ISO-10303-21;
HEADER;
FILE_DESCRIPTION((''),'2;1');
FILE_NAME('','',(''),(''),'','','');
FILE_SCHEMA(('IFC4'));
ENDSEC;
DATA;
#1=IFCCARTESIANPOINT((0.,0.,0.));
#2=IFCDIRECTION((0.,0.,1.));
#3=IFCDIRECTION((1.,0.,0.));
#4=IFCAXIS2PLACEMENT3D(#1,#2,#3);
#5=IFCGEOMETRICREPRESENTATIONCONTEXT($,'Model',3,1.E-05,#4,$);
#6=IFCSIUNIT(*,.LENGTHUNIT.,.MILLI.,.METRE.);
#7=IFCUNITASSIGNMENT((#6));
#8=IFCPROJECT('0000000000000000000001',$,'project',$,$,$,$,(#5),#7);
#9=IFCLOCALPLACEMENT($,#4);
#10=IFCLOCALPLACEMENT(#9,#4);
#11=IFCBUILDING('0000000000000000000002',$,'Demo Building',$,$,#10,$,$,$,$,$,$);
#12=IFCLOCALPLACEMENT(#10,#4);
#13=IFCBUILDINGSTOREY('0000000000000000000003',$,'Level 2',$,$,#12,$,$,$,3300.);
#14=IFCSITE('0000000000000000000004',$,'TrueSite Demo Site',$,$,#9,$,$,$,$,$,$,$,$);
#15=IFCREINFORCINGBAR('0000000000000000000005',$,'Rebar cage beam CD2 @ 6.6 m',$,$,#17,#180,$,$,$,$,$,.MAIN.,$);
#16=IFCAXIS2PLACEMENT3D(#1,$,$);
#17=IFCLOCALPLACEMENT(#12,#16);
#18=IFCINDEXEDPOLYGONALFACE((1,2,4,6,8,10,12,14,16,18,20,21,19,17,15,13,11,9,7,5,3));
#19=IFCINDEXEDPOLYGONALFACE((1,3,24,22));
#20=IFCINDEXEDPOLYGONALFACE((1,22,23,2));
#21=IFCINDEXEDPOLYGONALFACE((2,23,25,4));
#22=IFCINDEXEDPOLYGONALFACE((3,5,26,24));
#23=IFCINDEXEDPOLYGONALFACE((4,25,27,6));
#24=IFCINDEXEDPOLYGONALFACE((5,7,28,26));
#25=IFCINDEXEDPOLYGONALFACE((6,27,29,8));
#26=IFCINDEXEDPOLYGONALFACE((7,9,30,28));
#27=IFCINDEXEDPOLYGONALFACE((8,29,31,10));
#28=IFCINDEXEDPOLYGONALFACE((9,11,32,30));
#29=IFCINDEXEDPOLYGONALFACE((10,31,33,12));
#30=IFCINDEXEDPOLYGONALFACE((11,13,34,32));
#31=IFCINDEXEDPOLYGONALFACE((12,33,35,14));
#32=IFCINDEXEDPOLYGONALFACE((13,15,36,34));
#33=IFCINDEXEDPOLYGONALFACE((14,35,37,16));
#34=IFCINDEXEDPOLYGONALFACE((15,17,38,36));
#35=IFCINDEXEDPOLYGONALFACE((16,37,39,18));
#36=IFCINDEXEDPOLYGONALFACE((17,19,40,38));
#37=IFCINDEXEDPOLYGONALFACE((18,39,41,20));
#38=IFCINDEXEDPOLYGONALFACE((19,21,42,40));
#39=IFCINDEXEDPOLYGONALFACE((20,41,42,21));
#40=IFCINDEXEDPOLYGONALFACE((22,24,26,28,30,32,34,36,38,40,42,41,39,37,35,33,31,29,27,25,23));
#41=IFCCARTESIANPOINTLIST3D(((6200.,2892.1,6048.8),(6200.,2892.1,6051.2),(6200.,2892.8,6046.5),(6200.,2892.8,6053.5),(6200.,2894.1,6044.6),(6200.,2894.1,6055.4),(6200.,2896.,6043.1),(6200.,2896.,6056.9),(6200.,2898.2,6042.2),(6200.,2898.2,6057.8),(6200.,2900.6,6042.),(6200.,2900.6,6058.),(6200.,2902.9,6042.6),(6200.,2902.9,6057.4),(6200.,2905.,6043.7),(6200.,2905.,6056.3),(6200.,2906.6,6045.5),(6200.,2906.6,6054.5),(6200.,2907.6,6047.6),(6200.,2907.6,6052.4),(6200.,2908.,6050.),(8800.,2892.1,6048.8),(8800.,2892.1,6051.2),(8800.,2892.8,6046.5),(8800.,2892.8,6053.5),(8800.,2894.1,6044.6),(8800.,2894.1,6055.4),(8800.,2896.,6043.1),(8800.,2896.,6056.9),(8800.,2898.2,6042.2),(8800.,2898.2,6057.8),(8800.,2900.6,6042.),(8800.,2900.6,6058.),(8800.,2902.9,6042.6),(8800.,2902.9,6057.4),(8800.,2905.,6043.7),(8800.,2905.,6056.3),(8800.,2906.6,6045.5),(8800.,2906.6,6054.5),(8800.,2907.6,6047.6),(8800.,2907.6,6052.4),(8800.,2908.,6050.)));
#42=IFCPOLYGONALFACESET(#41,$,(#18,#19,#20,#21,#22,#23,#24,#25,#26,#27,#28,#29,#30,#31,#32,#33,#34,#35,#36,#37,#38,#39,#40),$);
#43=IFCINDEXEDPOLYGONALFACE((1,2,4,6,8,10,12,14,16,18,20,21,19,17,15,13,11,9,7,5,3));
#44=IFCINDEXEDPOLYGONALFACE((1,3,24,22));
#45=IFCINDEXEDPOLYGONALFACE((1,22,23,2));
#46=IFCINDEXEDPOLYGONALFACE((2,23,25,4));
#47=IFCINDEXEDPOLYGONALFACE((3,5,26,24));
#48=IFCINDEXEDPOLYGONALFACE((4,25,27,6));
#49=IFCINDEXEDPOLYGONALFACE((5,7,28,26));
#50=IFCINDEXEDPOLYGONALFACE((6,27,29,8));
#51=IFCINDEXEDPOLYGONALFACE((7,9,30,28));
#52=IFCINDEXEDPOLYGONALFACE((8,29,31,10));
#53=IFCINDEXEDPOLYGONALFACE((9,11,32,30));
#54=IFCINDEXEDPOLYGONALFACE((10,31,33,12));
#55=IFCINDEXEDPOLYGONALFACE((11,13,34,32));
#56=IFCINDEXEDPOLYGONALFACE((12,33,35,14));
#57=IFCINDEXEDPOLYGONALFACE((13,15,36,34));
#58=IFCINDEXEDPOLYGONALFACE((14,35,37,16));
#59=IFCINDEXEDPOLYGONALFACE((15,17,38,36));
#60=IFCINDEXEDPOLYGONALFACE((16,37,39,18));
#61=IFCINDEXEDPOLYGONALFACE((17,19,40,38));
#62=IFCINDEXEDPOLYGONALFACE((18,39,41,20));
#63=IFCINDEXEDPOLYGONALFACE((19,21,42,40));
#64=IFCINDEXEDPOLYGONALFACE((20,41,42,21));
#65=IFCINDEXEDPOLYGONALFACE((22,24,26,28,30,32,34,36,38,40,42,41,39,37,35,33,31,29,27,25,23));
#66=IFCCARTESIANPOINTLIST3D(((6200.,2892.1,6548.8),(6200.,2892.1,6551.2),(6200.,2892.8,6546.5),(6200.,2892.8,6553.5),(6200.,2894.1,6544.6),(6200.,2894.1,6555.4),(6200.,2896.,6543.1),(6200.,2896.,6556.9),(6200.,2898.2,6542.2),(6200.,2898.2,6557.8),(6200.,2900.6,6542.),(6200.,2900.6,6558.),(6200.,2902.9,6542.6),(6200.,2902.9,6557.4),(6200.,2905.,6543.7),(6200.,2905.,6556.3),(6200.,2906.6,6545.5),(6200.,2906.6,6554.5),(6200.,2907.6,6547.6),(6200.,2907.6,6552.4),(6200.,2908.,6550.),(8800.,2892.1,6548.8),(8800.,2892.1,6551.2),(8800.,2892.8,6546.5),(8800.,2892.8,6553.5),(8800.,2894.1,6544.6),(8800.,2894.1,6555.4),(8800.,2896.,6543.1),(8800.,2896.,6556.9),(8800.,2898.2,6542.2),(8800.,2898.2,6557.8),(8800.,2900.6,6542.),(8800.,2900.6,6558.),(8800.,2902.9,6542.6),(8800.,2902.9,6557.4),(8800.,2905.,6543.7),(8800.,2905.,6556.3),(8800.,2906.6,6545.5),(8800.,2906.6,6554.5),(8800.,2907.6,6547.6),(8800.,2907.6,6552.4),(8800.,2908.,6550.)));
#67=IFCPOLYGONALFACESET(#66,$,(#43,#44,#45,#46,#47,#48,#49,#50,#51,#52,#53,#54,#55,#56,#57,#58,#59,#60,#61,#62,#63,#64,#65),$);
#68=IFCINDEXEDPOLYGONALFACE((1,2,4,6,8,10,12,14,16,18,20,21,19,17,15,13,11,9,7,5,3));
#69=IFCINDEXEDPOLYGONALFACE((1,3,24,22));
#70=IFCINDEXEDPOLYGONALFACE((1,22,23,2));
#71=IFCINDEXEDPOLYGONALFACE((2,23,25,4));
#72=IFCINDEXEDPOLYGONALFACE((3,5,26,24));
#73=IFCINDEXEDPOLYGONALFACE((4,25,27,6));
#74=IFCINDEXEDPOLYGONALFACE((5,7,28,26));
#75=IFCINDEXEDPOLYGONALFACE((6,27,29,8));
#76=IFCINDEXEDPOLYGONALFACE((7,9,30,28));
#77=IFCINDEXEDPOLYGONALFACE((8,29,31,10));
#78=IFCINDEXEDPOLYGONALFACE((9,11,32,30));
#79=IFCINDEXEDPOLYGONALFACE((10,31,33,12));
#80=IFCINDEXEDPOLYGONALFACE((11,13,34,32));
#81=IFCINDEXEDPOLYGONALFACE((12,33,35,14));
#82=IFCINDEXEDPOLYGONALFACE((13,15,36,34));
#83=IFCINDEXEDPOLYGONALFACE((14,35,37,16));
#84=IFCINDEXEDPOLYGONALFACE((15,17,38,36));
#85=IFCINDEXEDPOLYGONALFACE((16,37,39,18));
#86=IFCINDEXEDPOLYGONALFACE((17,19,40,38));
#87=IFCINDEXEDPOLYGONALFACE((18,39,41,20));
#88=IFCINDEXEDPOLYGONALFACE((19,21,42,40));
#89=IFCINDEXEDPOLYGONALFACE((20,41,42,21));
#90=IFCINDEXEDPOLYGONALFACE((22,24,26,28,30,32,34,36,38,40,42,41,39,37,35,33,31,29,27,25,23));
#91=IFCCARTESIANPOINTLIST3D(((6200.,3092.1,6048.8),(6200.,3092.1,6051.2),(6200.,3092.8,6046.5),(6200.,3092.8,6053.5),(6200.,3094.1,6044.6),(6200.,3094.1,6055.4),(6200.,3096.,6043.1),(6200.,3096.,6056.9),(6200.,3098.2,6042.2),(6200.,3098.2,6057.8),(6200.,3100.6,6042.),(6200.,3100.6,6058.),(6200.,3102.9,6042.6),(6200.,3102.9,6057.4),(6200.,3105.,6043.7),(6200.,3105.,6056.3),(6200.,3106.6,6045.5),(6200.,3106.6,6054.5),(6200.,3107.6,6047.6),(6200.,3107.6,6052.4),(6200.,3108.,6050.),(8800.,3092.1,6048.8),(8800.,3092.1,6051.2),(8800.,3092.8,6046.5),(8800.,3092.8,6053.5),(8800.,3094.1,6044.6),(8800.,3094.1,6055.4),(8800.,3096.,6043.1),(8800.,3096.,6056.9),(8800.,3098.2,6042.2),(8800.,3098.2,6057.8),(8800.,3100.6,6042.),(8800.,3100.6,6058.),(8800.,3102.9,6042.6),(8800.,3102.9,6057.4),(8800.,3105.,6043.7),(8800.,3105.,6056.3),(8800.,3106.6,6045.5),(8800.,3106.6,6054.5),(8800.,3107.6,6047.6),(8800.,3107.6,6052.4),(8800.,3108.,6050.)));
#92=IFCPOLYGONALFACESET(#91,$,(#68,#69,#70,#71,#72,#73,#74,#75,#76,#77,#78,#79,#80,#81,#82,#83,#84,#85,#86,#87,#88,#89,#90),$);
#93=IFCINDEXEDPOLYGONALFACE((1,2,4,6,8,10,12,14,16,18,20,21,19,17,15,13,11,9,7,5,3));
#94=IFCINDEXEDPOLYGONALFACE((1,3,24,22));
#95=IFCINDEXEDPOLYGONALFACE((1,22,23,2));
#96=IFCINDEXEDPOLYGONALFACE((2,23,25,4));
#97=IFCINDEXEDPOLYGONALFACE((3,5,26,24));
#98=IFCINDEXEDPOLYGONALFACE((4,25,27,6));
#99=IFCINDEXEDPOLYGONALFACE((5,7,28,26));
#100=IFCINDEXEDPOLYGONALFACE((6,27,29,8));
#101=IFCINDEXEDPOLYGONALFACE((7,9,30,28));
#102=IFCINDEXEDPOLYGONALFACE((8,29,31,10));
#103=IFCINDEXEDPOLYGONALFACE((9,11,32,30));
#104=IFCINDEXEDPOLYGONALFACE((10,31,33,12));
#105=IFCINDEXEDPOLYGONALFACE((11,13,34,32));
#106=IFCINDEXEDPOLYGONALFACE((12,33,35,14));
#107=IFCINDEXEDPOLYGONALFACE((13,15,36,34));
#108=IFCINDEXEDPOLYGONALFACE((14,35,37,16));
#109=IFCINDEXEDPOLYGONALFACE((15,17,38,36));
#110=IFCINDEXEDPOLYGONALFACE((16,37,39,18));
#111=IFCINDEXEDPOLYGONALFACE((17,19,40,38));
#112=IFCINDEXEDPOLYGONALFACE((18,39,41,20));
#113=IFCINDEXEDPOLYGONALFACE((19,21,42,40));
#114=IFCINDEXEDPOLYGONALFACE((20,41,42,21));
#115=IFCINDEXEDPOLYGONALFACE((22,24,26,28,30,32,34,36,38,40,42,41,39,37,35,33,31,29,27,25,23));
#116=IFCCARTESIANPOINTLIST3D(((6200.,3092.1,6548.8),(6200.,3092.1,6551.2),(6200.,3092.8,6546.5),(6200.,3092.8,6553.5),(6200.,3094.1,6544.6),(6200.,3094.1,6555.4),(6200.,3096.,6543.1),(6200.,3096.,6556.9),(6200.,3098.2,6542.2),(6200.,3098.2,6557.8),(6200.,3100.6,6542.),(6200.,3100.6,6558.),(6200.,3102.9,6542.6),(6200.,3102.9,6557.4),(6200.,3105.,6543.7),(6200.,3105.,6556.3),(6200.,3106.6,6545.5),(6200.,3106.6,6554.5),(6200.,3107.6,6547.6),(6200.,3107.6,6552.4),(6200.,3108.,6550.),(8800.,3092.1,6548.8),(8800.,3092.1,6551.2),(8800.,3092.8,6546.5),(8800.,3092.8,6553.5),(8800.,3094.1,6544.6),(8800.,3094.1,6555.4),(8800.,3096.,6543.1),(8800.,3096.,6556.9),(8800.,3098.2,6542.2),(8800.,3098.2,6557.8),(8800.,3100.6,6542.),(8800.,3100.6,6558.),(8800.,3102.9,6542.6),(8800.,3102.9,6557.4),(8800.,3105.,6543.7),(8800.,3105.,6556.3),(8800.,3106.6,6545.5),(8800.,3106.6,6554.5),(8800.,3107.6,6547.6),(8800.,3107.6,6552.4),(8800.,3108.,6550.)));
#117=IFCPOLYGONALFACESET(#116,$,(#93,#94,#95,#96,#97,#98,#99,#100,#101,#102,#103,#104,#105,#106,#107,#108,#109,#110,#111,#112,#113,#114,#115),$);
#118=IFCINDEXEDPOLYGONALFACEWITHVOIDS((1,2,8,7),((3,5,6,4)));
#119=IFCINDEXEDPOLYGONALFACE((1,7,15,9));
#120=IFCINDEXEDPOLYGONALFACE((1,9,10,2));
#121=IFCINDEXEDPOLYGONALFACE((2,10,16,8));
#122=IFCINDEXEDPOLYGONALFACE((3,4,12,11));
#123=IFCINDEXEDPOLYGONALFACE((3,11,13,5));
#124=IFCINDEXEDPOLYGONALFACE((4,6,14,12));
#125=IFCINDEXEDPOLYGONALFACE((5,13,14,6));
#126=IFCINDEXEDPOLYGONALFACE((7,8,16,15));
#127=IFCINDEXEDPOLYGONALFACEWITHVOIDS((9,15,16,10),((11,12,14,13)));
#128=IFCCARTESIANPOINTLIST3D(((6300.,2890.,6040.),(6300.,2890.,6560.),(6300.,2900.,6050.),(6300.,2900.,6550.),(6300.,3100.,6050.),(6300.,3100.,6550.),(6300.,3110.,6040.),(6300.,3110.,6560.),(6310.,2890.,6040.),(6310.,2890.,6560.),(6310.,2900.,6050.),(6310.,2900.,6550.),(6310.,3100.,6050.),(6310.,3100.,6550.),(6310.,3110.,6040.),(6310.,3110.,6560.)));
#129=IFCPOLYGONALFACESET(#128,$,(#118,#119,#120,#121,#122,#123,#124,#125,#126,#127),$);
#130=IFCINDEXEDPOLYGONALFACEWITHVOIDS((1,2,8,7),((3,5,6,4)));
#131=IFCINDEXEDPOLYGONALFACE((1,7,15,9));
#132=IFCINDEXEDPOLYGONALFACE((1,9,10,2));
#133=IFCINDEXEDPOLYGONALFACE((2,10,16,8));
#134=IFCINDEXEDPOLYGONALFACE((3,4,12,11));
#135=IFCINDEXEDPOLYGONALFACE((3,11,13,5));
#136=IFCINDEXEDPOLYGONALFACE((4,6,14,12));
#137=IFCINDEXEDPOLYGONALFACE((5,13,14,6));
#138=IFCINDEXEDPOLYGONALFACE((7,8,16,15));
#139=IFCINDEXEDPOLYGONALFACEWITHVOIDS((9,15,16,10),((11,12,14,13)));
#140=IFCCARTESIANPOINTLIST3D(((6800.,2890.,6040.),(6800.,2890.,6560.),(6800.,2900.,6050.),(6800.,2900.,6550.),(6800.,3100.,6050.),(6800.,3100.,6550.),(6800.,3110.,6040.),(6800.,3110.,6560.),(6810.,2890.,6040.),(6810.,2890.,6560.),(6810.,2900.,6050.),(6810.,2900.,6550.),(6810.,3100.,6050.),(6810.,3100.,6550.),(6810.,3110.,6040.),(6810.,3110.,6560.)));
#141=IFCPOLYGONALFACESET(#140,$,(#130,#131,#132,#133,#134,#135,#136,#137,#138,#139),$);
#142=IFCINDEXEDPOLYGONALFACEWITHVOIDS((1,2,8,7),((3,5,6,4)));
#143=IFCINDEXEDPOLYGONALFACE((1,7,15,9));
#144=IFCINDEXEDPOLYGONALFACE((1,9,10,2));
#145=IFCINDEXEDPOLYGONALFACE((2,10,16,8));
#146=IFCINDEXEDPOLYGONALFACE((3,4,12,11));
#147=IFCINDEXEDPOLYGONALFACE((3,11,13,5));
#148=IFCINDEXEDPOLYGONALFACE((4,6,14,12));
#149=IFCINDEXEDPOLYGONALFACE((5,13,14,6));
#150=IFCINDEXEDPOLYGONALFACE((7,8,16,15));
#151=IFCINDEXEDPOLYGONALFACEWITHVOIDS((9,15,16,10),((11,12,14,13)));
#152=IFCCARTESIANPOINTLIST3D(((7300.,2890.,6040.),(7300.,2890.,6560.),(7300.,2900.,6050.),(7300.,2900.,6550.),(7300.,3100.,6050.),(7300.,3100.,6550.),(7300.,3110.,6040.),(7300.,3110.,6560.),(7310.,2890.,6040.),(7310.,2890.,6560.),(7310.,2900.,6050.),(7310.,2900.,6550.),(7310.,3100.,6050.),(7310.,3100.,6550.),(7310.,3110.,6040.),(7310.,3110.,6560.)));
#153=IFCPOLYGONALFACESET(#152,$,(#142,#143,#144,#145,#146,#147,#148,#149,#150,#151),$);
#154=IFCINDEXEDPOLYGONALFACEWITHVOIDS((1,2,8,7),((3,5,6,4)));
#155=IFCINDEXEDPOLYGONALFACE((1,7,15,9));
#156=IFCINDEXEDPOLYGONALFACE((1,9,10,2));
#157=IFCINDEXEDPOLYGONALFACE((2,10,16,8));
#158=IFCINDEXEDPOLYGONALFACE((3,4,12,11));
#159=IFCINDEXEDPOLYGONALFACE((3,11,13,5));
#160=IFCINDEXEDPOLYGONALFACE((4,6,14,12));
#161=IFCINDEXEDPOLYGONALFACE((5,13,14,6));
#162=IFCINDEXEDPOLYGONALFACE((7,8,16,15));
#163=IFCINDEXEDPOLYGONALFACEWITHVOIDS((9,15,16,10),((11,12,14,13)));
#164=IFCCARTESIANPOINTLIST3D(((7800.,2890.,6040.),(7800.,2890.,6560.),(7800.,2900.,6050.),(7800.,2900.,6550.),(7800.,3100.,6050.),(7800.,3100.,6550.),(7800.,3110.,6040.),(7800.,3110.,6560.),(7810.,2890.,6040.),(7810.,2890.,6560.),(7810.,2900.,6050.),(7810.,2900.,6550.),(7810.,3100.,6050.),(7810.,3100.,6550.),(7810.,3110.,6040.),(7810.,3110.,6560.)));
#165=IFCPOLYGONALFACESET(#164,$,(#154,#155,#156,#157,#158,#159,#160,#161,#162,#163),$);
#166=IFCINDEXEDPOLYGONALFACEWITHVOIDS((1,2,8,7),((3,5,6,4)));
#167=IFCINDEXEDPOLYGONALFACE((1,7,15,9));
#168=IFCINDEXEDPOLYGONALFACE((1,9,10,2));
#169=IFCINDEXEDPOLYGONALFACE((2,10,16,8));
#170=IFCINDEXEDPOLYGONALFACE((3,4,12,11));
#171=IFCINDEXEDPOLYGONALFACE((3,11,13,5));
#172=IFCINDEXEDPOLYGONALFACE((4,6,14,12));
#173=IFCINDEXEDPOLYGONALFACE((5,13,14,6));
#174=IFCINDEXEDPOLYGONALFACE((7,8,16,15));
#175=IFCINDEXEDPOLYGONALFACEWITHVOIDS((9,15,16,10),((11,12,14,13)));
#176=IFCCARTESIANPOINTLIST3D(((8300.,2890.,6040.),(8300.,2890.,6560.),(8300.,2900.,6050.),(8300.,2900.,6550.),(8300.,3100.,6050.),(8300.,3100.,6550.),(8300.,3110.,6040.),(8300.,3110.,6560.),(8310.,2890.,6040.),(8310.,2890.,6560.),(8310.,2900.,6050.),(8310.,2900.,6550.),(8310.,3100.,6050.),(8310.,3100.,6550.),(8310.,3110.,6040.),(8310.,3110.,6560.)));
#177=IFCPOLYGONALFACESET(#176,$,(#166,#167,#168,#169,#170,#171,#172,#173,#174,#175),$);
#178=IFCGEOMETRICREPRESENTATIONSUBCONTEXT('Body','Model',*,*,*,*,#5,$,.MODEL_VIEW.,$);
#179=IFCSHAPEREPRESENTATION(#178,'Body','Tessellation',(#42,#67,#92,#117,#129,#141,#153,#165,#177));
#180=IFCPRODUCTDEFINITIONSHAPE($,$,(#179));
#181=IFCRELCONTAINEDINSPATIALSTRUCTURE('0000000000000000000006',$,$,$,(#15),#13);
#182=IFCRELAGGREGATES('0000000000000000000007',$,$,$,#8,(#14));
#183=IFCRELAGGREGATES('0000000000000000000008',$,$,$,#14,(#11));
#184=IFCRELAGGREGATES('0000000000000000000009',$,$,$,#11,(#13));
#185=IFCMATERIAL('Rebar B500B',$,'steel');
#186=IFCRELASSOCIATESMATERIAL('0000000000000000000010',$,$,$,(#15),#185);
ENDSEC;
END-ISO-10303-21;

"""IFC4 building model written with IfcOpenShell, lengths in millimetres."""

from ifc_helpers import new_model, si_unit, frame, origin_with_axes, place, context, subcontext, project, spatial, hollow_rectangle, circle, extrude, material, element, save


model = new_model("IFC4")

# Units and contexts
model_context = context("Model", 3, precision=1e-05, world=origin_with_axes())
body_context = subcontext(model_context, "Body", "Model", "MODEL_VIEW")
ifc_project = project(units=[si_unit("LENGTHUNIT", "METRE", prefix="MILLI")], contexts=[model_context])

# Site, building, storey
site_placement = place(None, origin_with_axes())
site = spatial("IfcSite", under=ifc_project, at=site_placement, Name="TrueSite Demo Site")
building_placement = place(site_placement, origin_with_axes())
building = spatial("IfcBuilding", under=site, at=building_placement, Name="Demo Building")
storey_placement = place(building_placement, origin_with_axes())
storey = spatial("IfcBuildingStorey", under=building, at=storey_placement, Name="Level 2", Elevation=3300.0)

# Reinforcing bar
ifc_material_1 = material(Name="Rebar B500B", Category="steel")
for number, where, z_axis, x_axis, name in (
    (1, (6200.0, 3000.0, 6300.0), (1.0, 0.0, 0.0), (0.0, 1.0, 0.0), "Rebar cage beam CD2 @ 6.6 m"),
):
    element("IfcReinforcingBar", number, at=place(storey_placement, frame(where, z_axis=z_axis, x_axis=x_axis)), inside=storey, material=ifc_material_1, Name=name, PredefinedType="MAIN", context=body_context, shape_type="SweptSolid", body=[
        extrude(circle(Radius=8.0), frame((-100.0, -250.0, 0.0)), (0.0, 0.0, 1.0), 2600.0),
        extrude(circle(Radius=8.0), frame((-100.0, 250.0, 0.0)), (0.0, 0.0, 1.0), 2600.0),
        extrude(circle(Radius=8.0), frame((100.0, -250.0, 0.0)), (0.0, 0.0, 1.0), 2600.0),
        extrude(circle(Radius=8.0), frame((100.0, 250.0, 0.0)), (0.0, 0.0, 1.0), 2600.0),
        extrude(hollow_rectangle(XDim=220.0, YDim=520.0, WallThickness=10.0), frame((0.0, 0.0, 100.0)), (0.0, 0.0, 1.0), 10.0),
        extrude(hollow_rectangle(XDim=220.0, YDim=520.0, WallThickness=10.0), frame((0.0, 0.0, 600.0)), (0.0, 0.0, 1.0), 10.0),
        extrude(hollow_rectangle(XDim=220.0, YDim=520.0, WallThickness=10.0), frame((0.0, 0.0, 1100.0)), (0.0, 0.0, 1.0), 10.0),
        extrude(hollow_rectangle(XDim=220.0, YDim=520.0, WallThickness=10.0), frame((0.0, 0.0, 1600.0)), (0.0, 0.0, 1.0), 10.0),
        extrude(hollow_rectangle(XDim=220.0, YDim=520.0, WallThickness=10.0), frame((0.0, 0.0, 2100.0)), (0.0, 0.0, 1.0), 10.0),
    ])

save(model, "model.ifc")
